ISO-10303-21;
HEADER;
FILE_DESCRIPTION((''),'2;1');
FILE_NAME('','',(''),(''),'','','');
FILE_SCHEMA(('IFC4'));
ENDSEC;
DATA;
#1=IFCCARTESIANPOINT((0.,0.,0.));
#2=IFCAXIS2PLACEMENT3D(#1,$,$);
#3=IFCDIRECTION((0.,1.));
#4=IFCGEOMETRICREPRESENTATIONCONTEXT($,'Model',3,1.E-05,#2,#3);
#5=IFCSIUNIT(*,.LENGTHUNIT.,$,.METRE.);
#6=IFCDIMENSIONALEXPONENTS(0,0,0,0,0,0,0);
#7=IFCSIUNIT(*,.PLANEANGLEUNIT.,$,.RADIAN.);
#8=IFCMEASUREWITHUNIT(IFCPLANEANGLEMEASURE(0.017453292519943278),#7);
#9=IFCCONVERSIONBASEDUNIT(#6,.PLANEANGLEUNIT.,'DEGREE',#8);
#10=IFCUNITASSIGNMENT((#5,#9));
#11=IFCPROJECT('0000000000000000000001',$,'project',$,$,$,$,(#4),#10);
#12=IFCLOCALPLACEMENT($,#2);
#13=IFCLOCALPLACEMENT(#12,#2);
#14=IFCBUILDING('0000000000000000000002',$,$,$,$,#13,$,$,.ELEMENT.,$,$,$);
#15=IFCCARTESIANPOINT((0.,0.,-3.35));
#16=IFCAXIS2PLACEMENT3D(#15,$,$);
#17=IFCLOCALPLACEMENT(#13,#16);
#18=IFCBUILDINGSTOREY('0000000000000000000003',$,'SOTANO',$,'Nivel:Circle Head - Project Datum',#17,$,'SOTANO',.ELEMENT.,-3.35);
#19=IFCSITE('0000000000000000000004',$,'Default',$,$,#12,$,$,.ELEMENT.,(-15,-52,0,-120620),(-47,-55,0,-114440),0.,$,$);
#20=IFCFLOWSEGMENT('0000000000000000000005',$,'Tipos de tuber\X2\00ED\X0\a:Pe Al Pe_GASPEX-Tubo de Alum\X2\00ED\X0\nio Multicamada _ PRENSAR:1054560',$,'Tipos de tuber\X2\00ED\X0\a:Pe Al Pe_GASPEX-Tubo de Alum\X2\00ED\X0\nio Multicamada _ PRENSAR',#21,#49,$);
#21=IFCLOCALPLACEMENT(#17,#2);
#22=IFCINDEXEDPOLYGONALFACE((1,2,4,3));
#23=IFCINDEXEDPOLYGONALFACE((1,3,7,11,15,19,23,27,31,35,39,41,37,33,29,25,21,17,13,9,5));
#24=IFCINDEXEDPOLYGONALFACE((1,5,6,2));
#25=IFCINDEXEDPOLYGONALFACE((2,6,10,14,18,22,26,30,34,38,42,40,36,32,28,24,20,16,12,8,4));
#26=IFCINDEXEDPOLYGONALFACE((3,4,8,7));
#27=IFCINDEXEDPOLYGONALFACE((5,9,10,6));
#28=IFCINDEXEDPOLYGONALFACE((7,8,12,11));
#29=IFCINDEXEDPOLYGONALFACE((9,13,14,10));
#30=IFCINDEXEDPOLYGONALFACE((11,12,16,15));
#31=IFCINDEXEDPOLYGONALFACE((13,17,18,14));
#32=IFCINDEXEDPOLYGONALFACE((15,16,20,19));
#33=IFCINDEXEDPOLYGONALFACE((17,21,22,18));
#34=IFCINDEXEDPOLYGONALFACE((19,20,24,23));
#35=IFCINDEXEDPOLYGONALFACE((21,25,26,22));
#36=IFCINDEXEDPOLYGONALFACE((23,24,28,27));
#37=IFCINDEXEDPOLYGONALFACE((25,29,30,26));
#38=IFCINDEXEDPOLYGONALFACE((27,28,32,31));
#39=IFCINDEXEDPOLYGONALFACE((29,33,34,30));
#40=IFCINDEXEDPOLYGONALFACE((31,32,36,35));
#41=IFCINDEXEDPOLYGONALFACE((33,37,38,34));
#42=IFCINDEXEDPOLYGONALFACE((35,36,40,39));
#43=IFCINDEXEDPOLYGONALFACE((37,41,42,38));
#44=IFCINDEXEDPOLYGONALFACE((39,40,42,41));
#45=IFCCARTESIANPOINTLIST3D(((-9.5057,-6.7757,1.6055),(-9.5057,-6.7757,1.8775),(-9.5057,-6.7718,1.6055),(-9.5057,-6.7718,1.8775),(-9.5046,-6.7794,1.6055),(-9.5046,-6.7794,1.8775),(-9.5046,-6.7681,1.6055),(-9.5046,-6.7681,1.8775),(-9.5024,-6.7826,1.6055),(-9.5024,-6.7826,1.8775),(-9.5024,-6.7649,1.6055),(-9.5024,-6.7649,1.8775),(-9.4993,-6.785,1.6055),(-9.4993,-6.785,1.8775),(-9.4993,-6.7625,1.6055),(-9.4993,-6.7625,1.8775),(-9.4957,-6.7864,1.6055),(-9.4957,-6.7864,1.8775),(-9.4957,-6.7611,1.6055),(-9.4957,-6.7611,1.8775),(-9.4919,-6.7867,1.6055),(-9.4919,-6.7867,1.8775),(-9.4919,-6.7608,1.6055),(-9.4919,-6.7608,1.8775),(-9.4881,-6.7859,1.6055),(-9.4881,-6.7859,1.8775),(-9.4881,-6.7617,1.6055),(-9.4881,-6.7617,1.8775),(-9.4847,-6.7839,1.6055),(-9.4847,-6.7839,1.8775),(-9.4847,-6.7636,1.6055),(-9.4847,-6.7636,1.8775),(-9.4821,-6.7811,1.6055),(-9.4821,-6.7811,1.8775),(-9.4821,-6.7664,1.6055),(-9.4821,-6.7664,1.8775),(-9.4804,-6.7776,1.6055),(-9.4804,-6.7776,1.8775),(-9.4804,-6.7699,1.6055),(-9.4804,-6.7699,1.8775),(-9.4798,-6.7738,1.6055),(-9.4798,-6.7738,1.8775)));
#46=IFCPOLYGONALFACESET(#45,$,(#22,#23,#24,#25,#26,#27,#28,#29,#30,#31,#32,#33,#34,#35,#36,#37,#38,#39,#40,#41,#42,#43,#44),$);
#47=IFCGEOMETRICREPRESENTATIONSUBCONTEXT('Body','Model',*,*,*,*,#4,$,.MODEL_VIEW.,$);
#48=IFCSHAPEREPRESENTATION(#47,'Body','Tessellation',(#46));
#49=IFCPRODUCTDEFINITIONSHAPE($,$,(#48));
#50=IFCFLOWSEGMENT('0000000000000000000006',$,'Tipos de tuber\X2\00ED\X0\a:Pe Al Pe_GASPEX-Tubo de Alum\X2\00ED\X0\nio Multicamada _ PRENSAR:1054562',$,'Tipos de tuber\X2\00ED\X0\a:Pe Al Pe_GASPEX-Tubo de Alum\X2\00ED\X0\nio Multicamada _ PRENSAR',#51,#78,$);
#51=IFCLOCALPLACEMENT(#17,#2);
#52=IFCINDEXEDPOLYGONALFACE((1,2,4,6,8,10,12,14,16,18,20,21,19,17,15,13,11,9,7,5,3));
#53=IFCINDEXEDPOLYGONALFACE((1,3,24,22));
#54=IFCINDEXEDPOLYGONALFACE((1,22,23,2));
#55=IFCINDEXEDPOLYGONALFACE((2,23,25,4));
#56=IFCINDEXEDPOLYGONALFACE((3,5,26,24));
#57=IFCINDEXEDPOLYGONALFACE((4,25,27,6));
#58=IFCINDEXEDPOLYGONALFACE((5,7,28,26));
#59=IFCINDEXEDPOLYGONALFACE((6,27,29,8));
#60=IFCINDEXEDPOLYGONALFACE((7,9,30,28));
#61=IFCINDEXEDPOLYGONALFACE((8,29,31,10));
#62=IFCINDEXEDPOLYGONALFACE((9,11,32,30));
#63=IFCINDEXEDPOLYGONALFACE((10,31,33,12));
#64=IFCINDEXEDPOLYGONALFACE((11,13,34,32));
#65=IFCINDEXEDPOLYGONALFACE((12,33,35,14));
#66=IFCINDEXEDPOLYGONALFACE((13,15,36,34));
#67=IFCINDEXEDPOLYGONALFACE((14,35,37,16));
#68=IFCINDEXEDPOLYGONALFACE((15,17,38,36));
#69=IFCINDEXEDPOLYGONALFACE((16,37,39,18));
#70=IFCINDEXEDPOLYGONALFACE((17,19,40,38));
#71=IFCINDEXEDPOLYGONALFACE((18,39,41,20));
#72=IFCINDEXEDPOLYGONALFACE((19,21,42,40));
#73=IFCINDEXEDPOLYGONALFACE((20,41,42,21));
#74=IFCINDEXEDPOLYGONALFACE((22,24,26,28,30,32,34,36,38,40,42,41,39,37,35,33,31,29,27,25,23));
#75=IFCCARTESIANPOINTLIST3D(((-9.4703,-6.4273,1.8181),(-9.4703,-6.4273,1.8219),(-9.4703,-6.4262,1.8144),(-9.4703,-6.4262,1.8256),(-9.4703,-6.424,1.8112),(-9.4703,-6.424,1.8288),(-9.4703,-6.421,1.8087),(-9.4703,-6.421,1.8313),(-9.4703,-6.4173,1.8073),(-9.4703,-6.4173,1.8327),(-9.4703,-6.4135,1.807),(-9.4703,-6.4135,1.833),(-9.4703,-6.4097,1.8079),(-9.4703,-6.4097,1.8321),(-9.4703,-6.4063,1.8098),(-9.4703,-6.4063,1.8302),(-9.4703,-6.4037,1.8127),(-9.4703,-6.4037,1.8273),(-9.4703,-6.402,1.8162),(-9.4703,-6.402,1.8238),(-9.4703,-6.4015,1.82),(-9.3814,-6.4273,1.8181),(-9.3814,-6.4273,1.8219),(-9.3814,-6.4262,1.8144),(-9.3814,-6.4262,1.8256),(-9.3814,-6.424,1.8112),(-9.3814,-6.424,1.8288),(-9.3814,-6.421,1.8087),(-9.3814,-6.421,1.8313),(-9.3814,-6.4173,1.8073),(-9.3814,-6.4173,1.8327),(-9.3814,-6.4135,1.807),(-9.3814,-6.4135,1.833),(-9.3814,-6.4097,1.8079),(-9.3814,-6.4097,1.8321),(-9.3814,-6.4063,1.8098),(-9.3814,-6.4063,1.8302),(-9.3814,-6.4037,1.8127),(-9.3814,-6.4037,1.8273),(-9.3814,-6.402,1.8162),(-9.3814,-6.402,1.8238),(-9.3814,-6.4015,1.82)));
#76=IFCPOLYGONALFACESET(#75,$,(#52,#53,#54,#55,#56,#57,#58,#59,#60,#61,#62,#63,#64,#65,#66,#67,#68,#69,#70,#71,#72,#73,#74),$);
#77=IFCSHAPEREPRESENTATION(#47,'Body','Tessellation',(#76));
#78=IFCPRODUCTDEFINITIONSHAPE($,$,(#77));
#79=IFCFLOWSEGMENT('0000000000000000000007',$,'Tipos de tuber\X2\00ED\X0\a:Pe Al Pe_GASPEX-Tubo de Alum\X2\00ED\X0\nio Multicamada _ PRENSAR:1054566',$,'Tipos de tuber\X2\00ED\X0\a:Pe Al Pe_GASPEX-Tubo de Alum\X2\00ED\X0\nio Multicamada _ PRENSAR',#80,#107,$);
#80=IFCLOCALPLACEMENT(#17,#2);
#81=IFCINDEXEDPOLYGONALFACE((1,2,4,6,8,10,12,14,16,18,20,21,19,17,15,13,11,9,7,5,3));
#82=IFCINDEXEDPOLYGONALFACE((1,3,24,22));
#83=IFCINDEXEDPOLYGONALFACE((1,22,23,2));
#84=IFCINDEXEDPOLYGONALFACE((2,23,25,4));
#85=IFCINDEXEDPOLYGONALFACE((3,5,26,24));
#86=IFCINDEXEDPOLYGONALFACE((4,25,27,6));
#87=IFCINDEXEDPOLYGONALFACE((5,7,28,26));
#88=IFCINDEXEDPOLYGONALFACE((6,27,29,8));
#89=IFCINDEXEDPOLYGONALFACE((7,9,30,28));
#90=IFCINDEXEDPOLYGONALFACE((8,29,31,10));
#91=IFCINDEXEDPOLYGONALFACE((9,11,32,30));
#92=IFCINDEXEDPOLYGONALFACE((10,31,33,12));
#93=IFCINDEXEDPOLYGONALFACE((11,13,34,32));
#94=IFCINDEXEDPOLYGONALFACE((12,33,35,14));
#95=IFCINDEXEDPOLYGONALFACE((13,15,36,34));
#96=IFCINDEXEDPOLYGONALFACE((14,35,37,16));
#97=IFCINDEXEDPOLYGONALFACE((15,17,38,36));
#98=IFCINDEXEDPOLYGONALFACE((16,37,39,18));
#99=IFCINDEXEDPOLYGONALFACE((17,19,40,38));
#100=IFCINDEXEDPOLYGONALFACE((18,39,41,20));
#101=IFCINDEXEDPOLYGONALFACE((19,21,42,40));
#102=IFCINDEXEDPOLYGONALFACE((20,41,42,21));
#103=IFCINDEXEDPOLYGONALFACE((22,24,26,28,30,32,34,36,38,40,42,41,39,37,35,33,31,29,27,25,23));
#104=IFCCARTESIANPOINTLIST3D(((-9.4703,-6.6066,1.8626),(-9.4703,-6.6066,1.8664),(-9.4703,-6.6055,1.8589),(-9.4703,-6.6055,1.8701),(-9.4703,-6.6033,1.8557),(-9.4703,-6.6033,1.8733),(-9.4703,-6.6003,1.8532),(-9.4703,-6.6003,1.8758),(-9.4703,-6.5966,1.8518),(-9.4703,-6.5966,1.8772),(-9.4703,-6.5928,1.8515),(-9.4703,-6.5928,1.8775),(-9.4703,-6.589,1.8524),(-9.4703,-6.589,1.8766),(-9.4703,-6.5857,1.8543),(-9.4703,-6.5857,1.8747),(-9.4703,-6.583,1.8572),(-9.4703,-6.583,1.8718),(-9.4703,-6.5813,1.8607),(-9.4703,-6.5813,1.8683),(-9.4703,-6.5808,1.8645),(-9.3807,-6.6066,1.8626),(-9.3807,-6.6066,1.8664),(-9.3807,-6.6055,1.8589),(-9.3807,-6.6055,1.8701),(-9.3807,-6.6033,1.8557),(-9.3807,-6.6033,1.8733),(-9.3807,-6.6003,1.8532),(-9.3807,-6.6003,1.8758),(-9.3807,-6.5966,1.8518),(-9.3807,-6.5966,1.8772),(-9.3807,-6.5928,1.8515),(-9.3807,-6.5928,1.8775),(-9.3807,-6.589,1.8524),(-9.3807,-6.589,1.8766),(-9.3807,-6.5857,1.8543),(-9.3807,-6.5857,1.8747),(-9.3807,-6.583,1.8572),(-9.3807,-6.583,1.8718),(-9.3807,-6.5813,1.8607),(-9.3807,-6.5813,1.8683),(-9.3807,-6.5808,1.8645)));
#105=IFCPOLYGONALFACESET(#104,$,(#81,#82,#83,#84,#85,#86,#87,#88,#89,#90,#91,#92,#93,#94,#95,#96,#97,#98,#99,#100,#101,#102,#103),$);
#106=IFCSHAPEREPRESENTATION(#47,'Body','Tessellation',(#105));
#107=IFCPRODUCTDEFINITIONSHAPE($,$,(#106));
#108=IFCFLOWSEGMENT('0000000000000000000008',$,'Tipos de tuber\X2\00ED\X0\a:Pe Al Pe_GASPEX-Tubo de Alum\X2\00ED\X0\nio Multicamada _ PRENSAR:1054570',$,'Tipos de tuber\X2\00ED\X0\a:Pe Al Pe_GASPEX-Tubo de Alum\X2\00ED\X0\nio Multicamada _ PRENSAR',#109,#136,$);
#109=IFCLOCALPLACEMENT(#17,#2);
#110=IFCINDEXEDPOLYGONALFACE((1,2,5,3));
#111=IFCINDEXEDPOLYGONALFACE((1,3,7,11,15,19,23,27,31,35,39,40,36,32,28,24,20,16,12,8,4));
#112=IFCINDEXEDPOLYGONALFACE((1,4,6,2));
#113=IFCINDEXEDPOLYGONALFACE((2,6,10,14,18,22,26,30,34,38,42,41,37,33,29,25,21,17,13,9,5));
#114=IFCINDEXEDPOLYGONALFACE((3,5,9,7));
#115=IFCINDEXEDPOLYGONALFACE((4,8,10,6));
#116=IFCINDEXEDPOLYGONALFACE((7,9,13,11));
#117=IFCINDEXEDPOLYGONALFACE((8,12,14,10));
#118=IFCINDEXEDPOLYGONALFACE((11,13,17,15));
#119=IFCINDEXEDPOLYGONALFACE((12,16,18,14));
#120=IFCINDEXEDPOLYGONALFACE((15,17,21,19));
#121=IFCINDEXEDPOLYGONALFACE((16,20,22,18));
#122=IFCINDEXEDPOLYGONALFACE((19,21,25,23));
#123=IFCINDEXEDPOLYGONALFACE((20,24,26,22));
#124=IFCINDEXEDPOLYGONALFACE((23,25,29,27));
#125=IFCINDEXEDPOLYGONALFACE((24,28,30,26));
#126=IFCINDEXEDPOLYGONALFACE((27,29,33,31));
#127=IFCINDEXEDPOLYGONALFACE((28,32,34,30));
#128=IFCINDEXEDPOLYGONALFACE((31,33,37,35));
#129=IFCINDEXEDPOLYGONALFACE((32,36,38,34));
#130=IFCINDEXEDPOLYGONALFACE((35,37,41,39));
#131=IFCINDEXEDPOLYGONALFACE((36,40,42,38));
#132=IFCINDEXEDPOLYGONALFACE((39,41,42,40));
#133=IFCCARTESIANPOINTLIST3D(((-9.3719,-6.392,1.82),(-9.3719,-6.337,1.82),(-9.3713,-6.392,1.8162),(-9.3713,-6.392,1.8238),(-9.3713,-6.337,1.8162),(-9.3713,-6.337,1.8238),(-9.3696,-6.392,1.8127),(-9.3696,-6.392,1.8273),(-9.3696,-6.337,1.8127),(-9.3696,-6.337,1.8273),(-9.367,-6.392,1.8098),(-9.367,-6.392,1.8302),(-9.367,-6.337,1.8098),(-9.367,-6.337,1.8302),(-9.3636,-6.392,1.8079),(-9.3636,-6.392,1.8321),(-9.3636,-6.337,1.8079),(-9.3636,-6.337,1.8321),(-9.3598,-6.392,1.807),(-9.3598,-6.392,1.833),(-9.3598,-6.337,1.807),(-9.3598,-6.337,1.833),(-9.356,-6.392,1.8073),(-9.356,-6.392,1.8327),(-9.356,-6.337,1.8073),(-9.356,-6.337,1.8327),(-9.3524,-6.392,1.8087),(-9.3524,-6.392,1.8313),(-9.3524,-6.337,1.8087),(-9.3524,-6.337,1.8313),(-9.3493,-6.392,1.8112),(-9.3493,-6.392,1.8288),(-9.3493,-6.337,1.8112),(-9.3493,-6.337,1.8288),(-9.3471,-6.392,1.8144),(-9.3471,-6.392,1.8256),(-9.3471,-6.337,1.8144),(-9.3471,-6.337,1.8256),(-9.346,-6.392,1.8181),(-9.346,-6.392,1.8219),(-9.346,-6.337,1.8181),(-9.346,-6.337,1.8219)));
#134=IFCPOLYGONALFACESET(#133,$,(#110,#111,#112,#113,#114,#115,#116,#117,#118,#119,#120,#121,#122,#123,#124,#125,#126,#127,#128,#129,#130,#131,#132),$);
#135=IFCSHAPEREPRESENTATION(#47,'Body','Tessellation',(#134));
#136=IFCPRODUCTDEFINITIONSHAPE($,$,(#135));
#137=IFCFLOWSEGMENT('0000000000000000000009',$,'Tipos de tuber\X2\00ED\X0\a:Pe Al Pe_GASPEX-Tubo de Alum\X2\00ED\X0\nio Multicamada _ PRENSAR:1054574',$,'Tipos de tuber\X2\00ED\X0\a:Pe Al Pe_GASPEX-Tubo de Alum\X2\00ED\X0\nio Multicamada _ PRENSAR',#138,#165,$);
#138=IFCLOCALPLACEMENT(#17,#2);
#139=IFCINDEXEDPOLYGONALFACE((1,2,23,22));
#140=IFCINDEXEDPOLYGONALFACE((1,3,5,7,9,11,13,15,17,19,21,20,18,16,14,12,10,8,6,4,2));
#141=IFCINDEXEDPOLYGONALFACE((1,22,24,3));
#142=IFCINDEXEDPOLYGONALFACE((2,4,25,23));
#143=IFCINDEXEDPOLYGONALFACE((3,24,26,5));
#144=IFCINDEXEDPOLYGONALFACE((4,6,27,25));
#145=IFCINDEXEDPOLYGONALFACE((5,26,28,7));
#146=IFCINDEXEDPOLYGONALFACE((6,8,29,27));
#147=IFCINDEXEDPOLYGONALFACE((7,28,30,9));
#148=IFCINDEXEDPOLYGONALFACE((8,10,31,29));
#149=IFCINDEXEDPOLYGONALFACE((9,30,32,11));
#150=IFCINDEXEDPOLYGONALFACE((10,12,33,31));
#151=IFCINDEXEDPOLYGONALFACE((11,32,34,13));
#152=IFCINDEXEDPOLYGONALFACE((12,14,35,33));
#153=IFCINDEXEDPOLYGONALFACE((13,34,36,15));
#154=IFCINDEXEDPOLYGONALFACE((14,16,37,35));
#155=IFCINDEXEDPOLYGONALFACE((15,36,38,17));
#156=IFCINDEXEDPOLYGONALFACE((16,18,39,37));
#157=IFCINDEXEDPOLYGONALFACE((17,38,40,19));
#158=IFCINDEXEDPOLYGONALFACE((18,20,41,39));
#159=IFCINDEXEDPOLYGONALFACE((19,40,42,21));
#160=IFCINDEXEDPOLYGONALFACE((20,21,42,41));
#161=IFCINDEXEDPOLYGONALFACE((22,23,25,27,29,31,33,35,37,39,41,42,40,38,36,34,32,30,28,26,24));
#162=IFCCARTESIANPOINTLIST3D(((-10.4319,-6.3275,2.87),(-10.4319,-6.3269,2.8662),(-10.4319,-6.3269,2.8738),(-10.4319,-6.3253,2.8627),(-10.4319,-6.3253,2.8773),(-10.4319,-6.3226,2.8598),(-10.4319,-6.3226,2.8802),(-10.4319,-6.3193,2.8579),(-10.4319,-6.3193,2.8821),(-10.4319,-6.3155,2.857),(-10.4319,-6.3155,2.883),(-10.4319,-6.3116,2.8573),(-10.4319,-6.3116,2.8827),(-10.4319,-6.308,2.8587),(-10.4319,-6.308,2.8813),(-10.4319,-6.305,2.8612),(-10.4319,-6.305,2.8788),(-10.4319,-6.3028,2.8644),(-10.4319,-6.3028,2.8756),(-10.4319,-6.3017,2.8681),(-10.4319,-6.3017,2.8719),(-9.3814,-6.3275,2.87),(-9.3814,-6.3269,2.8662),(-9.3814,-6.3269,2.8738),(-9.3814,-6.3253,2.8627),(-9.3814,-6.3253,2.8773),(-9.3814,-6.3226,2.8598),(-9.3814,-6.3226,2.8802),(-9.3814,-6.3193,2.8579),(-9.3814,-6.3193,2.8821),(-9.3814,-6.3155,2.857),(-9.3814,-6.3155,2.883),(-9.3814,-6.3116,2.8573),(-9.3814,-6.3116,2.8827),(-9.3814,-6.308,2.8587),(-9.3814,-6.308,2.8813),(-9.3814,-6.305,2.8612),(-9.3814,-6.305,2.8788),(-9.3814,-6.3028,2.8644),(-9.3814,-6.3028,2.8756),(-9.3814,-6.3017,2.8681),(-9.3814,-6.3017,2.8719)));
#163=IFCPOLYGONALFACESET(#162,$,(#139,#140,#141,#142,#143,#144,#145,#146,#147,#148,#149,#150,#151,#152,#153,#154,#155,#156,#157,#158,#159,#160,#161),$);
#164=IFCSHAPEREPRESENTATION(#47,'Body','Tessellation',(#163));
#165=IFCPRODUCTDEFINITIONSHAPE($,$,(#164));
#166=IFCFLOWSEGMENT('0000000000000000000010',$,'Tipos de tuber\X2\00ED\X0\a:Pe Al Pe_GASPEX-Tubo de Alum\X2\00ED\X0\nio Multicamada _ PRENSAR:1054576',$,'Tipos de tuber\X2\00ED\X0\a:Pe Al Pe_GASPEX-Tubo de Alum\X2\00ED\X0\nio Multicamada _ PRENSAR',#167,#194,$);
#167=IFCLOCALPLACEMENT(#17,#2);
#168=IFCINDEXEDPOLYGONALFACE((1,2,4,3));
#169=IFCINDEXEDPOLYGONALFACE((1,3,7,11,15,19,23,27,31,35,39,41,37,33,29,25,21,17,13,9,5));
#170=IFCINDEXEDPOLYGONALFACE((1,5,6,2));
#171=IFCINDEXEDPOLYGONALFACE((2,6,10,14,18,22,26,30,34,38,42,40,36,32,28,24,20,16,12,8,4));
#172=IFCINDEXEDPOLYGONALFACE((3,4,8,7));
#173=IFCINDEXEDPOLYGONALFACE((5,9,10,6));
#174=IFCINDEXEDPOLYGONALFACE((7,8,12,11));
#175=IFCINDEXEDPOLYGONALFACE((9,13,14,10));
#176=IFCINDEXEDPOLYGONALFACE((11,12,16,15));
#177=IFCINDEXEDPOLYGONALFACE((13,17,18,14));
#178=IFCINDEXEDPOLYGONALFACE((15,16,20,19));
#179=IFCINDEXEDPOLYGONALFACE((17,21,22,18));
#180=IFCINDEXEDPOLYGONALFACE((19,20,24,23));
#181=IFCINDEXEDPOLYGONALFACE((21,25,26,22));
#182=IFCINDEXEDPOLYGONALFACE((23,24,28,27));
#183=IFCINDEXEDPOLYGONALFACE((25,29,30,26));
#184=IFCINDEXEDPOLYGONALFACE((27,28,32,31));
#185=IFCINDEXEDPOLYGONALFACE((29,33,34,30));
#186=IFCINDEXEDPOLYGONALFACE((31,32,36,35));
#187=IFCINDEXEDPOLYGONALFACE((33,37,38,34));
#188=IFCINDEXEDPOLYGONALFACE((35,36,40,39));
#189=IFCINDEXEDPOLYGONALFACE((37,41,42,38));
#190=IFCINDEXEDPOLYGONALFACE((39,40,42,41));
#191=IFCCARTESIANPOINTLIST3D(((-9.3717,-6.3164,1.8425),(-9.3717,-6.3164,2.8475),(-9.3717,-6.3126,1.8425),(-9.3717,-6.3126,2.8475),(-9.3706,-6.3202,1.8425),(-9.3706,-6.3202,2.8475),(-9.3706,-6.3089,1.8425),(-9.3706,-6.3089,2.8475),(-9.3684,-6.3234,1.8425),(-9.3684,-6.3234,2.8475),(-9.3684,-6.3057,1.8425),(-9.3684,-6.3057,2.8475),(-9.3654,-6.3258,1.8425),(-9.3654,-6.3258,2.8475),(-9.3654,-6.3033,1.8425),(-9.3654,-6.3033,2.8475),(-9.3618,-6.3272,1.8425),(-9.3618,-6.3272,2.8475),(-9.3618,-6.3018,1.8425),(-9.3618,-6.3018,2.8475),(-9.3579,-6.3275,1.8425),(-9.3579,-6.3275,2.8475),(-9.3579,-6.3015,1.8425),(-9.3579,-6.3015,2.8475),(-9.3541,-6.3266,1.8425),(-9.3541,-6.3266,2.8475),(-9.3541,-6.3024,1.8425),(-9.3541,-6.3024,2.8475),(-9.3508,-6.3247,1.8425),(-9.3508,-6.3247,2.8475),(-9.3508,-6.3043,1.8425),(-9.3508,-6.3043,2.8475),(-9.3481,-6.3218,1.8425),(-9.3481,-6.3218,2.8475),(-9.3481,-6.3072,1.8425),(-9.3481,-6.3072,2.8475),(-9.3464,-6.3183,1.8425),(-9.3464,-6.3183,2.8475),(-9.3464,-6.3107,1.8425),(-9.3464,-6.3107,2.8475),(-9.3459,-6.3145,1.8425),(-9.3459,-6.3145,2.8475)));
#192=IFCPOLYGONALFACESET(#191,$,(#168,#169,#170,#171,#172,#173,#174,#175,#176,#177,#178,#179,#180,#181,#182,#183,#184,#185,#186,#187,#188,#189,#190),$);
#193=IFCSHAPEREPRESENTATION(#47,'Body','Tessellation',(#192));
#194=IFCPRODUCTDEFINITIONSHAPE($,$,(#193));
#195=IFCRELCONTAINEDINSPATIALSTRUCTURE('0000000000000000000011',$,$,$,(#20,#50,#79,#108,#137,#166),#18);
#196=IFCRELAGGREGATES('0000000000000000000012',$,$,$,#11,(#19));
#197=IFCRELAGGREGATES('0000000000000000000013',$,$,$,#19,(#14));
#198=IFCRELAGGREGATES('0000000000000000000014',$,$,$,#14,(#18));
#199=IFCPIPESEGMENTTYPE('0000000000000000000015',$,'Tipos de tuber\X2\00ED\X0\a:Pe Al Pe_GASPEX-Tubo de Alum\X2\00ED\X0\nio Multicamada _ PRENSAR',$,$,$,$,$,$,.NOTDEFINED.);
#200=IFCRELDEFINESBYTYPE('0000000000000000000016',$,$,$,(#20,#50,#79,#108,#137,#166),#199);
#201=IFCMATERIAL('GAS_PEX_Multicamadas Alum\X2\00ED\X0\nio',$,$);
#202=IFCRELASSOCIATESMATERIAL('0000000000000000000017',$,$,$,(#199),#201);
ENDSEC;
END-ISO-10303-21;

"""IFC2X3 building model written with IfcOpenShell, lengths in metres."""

from ifc_helpers import new_model, entity, si_unit, converted_unit, direction, frame, frame_2d, origin, origin_2d_with_axis, place, context, subcontext, project, spatial, circle, extrude, material, type_object, element, save


model = new_model("IFC2X3")

# Units and contexts
model_context = context("Model", 3, precision=1e-05, world=origin(), true_north=direction((0.0, 1.0)))
body_context = subcontext(model_context, "Body", "Model", "MODEL_VIEW")
ifc_project = project(units=[si_unit("LENGTHUNIT", "METRE"), converted_unit("PLANEANGLEUNIT", "DEGREE", entity("IfcPlaneAngleMeasure", 0.017453292519943278), si_unit("PLANEANGLEUNIT", "RADIAN"), dimensions=[0, 0, 0, 0, 0, 0, 0])], contexts=[model_context])

# Site, building, storey
site_placement = place(None, origin())
site = spatial("IfcSite", under=ifc_project, at=site_placement, Name="Default", CompositionType="ELEMENT", RefLatitude=(-15, -52, 0, -120620), RefLongitude=(-47, -55, 0, -114440), RefElevation=0.0)
building_placement = place(site_placement, origin())
building = spatial("IfcBuilding", under=site, at=building_placement, CompositionType="ELEMENT")
storey_placement = place(building_placement, frame((0.0, 0.0, -3.35)))
storey = spatial("IfcBuildingStorey", under=building, at=storey_placement, Name="SOTANO", ObjectType="Nivel:Circle Head - Project Datum", LongName="SOTANO", CompositionType="ELEMENT", Elevation=-3.35)

# Flow segments
ifc_material = material(Name="GAS_PEX_Multicamadas Alumínio")
pipe_segment_type_1 = type_object("IfcPipeSegmentType", Name="Tipos de tubería:Pe Al Pe_GASPEX-Tubo de Alumínio Multicamada _ PRENSAR", PredefinedType="NOTDEFINED", material=ifc_material)
flow_segment_1_placement = place(storey_placement, origin())
element("IfcFlowSegment", 1, at=flow_segment_1_placement, inside=storey, type_object=pipe_segment_type_1, Name="Tipos de tubería:Pe Al Pe_GASPEX-Tubo de Alumínio Multicamada _ PRENSAR:1054560", ObjectType="Tipos de tubería:Pe Al Pe_GASPEX-Tubo de Alumínio Multicamada _ PRENSAR", context=body_context, shape_type="SweptSolid", body=[
    extrude(circle(Radius=0.013, at=frame_2d((0.0, 0.0), x_axis=(1.0, 0.0))), frame((-9.4928, -6.7738, 1.6055)), (0.0, 0.0, 1.0), 0.272),
])
flow_segment_2_placement = place(storey_placement, origin())
element("IfcFlowSegment", 2, at=flow_segment_2_placement, inside=storey, type_object=pipe_segment_type_1, Name="Tipos de tubería:Pe Al Pe_GASPEX-Tubo de Alumínio Multicamada _ PRENSAR:1054562", ObjectType="Tipos de tubería:Pe Al Pe_GASPEX-Tubo de Alumínio Multicamada _ PRENSAR", context=body_context, shape_type="SweptSolid", body=[
    extrude(circle(Radius=0.013, at=origin_2d_with_axis()), frame((-9.4703, -6.4145, 1.82), z_axis=(1.0, 0.0, 0.0), x_axis=(0.0, 1.0, 0.0)), (0.0, 0.0, 1.0), 0.089),
])
flow_segment_3_placement = place(storey_placement, origin())
element("IfcFlowSegment", 3, at=flow_segment_3_placement, inside=storey, type_object=pipe_segment_type_1, Name="Tipos de tubería:Pe Al Pe_GASPEX-Tubo de Alumínio Multicamada _ PRENSAR:1054566", ObjectType="Tipos de tubería:Pe Al Pe_GASPEX-Tubo de Alumínio Multicamada _ PRENSAR", context=body_context, shape_type="SweptSolid", body=[
    extrude(circle(Radius=0.013, at=origin_2d_with_axis()), frame((-9.4703, -6.5938, 1.8645), z_axis=(1.0, 0.0, 0.0), x_axis=(0.0, 1.0, 0.0)), (0.0, 0.0, 1.0), 0.0896),
])
flow_segment_4_placement = place(storey_placement, origin())
element("IfcFlowSegment", 4, at=flow_segment_4_placement, inside=storey, type_object=pipe_segment_type_1, Name="Tipos de tubería:Pe Al Pe_GASPEX-Tubo de Alumínio Multicamada _ PRENSAR:1054570", ObjectType="Tipos de tubería:Pe Al Pe_GASPEX-Tubo de Alumínio Multicamada _ PRENSAR", context=body_context, shape_type="SweptSolid", body=[
    extrude(circle(Radius=0.013, at=origin_2d_with_axis()), frame((-9.3589, -6.392, 1.82), z_axis=(0.0, 1.0, 0.0), x_axis=(-1.0, 0.0, 0.0)), (0.0, 0.0, 1.0), 0.0549),
])
flow_segment_5_placement = place(storey_placement, origin())
element("IfcFlowSegment", 5, at=flow_segment_5_placement, inside=storey, type_object=pipe_segment_type_1, Name="Tipos de tubería:Pe Al Pe_GASPEX-Tubo de Alumínio Multicamada _ PRENSAR:1054574", ObjectType="Tipos de tubería:Pe Al Pe_GASPEX-Tubo de Alumínio Multicamada _ PRENSAR", context=body_context, shape_type="SweptSolid", body=[
    extrude(circle(Radius=0.013, at=origin_2d_with_axis()), frame((-10.4319, -6.3145, 2.87), z_axis=(1.0, 0.0, 0.0), x_axis=(0.0, -1.0, 0.0)), (0.0, 0.0, 1.0), 1.0505),
])
flow_segment_6_placement = place(storey_placement, origin())
element("IfcFlowSegment", 6, at=flow_segment_6_placement, inside=storey, type_object=pipe_segment_type_1, Name="Tipos de tubería:Pe Al Pe_GASPEX-Tubo de Alumínio Multicamada _ PRENSAR:1054576", ObjectType="Tipos de tubería:Pe Al Pe_GASPEX-Tubo de Alumínio Multicamada _ PRENSAR", context=body_context, shape_type="SweptSolid", body=[
    extrude(circle(Radius=0.013, at=frame_2d((0.0, 0.0), x_axis=(1.0, 0.0))), frame((-9.3589, -6.3145, 1.8425)), (0.0, 0.0, 1.0), 1.005),
])

save(model, "model.ifc")
